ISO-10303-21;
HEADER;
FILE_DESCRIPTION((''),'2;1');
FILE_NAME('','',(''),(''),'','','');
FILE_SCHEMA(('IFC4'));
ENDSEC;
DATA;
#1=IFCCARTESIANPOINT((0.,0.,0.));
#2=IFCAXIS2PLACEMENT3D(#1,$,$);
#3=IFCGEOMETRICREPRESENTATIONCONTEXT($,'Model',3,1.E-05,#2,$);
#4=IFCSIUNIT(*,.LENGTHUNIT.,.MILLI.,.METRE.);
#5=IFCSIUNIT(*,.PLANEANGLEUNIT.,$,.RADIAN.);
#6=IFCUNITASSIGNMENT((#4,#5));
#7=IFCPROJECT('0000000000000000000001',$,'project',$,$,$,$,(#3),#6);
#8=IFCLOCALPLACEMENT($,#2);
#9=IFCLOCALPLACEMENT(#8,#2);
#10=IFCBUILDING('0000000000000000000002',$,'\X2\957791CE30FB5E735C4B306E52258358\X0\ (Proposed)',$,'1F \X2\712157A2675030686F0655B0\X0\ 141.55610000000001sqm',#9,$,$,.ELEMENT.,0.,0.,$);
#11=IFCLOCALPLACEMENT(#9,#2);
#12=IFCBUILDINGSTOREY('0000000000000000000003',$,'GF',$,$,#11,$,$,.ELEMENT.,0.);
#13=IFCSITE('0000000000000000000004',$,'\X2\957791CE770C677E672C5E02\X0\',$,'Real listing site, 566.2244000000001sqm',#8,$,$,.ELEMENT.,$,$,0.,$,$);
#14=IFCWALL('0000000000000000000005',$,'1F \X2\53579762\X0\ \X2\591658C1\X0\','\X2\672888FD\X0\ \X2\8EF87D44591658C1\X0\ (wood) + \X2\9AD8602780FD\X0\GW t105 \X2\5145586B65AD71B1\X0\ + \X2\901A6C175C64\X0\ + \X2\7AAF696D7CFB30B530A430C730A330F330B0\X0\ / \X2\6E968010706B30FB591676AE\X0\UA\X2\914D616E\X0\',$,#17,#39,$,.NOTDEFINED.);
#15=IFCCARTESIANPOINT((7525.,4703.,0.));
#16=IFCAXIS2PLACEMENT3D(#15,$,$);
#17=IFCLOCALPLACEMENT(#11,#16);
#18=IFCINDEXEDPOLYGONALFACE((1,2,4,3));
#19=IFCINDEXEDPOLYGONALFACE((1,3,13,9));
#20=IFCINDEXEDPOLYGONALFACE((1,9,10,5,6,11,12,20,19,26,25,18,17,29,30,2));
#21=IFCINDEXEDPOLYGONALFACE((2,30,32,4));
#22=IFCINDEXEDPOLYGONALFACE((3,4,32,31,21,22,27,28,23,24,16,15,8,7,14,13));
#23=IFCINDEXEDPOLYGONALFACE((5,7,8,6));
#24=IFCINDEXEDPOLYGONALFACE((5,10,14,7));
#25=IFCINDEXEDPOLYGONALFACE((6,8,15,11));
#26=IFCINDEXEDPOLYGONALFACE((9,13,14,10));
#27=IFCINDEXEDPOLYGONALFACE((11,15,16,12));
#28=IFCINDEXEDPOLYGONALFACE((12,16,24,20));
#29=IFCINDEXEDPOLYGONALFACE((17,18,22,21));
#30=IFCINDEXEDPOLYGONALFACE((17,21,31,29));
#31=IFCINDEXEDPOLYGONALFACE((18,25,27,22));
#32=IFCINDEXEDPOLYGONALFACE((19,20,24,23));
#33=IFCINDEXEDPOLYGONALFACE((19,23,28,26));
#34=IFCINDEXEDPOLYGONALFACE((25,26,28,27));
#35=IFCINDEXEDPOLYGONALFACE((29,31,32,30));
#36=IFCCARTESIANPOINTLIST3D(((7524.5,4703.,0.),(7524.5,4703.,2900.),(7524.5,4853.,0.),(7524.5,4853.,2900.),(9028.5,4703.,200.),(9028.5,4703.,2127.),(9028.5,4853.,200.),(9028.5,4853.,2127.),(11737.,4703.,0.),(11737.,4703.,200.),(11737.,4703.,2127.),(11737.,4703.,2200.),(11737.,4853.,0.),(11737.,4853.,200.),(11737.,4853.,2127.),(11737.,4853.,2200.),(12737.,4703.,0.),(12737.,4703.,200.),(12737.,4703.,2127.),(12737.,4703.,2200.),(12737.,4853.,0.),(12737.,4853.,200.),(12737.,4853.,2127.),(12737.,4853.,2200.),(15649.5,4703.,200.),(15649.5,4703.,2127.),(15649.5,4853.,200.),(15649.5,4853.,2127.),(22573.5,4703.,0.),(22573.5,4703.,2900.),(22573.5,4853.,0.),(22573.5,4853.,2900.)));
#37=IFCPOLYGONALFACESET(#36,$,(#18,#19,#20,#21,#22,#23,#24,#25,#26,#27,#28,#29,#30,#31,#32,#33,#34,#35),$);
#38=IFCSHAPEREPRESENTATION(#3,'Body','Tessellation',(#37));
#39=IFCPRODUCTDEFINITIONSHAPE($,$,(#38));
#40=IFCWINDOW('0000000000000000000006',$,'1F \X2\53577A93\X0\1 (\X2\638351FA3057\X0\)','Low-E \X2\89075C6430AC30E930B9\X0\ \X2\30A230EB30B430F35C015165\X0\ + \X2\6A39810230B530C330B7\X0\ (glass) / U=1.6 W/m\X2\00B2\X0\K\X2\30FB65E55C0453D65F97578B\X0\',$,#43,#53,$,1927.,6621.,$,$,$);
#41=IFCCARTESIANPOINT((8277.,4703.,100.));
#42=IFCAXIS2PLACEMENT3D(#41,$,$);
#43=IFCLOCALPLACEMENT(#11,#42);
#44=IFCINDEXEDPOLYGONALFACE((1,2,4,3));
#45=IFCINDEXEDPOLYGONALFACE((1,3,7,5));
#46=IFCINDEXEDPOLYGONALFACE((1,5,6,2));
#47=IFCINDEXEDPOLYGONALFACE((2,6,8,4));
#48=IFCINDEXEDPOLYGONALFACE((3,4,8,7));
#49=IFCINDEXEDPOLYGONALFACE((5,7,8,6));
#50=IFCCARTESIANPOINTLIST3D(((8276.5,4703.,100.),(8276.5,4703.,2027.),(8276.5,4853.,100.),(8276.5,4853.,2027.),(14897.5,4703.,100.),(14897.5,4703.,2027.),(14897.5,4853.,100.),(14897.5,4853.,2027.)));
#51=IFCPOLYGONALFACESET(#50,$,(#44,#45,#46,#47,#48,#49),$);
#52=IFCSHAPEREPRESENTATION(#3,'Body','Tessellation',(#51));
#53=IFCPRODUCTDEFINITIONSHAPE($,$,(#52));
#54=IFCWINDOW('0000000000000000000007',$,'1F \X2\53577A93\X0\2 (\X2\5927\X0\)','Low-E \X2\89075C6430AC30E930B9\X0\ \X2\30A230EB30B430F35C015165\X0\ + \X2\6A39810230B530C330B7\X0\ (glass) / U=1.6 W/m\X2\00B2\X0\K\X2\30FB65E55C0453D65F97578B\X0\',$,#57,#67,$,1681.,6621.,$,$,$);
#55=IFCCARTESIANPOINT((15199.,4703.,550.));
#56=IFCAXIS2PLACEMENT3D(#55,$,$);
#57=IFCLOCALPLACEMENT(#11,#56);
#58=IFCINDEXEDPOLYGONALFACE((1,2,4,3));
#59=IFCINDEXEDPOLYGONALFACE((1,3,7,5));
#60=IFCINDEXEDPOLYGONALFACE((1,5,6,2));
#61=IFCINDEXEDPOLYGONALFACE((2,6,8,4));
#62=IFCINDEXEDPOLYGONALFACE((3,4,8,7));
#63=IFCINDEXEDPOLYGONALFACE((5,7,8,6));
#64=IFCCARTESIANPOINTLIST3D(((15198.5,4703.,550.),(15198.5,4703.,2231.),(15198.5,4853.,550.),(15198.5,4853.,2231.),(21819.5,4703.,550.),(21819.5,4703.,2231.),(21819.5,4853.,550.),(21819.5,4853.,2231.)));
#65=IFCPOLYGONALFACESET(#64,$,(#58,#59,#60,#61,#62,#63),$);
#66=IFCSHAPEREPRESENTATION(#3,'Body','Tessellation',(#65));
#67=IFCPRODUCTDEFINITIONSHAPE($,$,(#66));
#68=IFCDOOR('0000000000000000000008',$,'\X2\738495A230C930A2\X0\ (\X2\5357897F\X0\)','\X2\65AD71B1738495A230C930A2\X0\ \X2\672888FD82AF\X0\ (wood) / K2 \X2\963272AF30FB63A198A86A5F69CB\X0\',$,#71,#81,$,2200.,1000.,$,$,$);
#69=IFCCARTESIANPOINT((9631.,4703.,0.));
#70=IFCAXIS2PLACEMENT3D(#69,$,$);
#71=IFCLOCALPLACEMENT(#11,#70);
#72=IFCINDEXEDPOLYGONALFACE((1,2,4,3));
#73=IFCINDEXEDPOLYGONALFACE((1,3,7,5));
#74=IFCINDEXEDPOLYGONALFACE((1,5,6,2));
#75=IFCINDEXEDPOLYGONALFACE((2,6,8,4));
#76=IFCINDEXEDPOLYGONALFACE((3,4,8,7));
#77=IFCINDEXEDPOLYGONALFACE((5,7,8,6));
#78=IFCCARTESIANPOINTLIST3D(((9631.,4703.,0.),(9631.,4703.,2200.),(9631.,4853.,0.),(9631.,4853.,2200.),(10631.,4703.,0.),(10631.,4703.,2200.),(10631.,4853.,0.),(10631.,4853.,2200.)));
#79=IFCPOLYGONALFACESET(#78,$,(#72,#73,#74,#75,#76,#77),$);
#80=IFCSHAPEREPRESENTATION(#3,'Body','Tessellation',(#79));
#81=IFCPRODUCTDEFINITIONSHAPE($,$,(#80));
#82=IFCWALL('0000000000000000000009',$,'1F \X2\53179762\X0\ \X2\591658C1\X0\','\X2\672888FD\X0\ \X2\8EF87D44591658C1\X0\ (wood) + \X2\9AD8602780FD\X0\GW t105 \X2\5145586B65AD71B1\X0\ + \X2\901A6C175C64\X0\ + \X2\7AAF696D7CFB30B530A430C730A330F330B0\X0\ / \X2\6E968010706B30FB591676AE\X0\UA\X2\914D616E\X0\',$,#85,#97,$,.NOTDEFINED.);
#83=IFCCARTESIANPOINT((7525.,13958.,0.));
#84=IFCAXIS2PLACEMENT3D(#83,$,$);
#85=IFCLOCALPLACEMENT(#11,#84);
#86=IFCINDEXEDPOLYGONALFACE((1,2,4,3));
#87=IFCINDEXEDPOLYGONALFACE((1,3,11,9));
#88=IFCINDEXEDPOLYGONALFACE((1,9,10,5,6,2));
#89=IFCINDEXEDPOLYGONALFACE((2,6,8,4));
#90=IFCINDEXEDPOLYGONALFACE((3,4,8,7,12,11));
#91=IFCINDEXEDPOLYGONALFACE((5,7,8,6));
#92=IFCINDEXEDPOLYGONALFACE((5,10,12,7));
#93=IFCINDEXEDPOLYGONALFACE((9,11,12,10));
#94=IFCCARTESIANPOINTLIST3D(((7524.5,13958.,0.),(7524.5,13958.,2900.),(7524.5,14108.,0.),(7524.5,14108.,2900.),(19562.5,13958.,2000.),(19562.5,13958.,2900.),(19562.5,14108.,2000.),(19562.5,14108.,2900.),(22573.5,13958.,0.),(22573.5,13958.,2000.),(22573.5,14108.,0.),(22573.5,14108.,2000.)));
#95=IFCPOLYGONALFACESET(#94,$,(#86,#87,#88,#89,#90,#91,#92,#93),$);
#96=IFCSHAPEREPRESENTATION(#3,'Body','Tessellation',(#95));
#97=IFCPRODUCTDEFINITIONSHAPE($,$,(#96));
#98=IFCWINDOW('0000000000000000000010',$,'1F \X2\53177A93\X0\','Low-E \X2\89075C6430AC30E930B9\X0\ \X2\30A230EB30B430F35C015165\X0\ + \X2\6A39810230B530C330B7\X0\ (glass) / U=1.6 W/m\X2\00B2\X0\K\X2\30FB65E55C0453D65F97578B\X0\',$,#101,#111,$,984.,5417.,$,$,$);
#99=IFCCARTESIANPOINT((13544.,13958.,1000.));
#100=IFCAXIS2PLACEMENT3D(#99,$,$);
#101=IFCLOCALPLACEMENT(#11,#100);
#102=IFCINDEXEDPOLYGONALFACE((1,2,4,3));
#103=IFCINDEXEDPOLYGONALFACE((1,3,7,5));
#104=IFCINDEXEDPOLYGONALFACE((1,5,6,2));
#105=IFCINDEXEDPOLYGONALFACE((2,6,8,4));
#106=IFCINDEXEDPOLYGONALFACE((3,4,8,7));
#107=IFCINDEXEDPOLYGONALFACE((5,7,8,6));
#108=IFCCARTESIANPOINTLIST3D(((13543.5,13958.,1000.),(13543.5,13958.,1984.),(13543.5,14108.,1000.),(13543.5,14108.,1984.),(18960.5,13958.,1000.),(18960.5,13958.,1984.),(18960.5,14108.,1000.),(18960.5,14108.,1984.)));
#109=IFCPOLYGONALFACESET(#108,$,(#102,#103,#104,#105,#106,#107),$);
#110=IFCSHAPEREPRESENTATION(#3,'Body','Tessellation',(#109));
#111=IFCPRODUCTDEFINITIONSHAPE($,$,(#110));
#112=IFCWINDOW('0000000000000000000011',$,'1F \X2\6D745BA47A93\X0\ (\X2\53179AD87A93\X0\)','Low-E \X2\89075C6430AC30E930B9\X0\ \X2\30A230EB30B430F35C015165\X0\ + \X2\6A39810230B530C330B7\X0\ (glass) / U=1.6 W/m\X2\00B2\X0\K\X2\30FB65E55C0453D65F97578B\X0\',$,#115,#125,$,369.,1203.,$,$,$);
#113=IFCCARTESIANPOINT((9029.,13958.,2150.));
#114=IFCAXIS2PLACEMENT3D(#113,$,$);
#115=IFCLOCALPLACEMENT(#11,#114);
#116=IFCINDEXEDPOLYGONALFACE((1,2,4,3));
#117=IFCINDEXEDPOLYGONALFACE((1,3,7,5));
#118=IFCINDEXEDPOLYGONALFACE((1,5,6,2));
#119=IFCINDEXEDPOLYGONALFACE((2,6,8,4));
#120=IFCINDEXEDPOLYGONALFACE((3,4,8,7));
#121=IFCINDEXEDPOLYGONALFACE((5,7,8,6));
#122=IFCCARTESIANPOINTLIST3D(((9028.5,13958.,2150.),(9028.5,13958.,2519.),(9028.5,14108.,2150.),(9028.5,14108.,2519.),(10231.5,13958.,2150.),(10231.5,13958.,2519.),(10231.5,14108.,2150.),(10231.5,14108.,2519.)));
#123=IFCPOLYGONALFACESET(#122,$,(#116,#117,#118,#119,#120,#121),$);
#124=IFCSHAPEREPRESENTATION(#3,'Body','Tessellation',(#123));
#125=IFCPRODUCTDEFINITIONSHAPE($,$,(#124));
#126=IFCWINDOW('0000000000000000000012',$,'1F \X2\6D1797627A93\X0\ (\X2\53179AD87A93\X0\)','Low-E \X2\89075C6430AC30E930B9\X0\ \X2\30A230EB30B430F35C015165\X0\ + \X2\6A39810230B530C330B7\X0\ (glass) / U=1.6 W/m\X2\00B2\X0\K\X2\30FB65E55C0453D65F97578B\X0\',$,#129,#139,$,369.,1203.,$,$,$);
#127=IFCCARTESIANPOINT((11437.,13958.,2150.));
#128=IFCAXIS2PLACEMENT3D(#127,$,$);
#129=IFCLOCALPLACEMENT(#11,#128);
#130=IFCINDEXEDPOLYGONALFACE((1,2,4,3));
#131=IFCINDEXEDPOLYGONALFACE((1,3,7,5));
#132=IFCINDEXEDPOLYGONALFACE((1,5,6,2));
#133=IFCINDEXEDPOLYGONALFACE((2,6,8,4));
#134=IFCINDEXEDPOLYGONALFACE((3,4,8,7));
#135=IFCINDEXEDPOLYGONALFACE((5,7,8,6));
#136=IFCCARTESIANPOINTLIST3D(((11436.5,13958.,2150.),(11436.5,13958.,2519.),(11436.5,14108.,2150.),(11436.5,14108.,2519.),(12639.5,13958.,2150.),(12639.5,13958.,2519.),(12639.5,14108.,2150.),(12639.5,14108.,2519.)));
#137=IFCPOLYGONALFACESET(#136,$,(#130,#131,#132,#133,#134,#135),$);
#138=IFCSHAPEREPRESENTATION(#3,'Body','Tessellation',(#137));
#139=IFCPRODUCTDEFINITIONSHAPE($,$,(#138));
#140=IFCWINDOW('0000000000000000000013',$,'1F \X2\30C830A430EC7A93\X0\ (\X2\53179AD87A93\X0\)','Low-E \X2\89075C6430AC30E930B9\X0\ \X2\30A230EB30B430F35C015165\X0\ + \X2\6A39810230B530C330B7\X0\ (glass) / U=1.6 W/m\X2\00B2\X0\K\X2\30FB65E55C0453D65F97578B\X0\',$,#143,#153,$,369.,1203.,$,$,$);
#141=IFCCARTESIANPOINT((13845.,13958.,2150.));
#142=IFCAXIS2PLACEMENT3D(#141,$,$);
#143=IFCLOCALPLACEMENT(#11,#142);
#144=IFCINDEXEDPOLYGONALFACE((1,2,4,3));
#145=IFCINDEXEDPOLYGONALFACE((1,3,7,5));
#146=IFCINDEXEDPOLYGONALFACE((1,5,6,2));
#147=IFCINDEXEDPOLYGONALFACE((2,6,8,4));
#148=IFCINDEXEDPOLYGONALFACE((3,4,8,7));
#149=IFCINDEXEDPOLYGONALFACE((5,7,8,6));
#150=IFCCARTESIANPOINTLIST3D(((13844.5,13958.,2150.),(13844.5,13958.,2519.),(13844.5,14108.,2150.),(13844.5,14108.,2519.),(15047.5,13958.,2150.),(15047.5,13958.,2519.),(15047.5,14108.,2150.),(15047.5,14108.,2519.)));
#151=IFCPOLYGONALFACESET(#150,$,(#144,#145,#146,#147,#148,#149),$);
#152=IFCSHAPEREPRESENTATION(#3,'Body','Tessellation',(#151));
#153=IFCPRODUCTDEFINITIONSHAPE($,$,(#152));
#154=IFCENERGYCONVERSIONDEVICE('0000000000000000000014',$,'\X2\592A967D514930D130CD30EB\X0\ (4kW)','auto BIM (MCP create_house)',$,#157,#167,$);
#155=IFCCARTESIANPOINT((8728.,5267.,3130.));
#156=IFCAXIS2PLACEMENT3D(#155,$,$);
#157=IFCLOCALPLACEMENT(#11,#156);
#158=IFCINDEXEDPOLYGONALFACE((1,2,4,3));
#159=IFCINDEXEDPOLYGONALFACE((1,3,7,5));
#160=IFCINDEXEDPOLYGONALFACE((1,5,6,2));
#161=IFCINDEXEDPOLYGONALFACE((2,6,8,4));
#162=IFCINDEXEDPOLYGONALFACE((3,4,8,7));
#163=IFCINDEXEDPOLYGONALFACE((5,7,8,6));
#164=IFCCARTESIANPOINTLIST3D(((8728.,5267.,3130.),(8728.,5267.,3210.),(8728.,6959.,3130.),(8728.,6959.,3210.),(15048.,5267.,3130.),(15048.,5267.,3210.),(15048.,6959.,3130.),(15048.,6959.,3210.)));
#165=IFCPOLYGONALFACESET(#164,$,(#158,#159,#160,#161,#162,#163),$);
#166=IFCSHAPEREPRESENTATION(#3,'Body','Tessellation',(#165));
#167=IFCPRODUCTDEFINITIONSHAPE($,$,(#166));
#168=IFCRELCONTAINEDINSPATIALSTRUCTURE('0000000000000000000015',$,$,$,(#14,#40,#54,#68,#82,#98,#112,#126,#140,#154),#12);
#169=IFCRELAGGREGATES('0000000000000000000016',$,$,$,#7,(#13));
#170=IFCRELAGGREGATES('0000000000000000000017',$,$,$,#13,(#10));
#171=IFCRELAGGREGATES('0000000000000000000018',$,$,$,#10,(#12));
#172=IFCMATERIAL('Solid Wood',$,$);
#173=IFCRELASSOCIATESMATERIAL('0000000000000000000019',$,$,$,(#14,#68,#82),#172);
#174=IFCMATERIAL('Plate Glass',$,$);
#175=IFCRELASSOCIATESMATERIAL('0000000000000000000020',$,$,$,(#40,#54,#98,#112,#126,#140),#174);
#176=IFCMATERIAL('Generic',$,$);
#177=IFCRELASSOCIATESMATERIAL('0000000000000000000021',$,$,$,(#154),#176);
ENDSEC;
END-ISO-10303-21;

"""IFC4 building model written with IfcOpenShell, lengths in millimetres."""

from ifc_helpers import new_model, si_unit, frame, frame_2d, origin, place, context, project, spatial, rectangle, extrude, material, element, fill, save


model = new_model("IFC4")

# Units and contexts
model_context = context("Model", 3, precision=1e-05, world=origin())
ifc_project = project(units=[si_unit("LENGTHUNIT", "METRE", prefix="MILLI"), si_unit("PLANEANGLEUNIT", "RADIAN")], contexts=[model_context])

# Site, building, storey
site_placement = place(None, origin())
site = spatial("IfcSite", under=ifc_project, at=site_placement, Name="長野県松本市", ObjectType="Real listing site, 566.2244000000001sqm", CompositionType="ELEMENT", RefElevation=0.0)
building_placement = place(site_placement, origin())
building = spatial("IfcBuilding", under=site, at=building_placement, Name="長野・平屋の別荘 (Proposed)", ObjectType="1F 無垢材と漆喰 141.55610000000001sqm", CompositionType="ELEMENT", ElevationOfRefHeight=0.0, ElevationOfTerrain=0.0)
storey_placement = place(building_placement, origin())
storey = spatial("IfcBuildingStorey", under=building, at=storey_placement, Name="GF", CompositionType="ELEMENT", Elevation=0.0)

# Shared definitions
ifc_material_1 = material(Name="Solid Wood")

# Wall, openings, windows, door
wall_1_placement = place(storey_placement, frame((7525.0, 4703.0, 0.0)))
wall_1 = element("IfcWall", 1, at=wall_1_placement, inside=storey, material=ifc_material_1, Name="1F 南面 外壁", Description="木製 軸組外壁 (wood) + 高性能GW t105 充填断熱 + 通気層 + 窯業系サイディング / 準耐火・外皮UA配慮", PredefinedType="NOTDEFINED", context=model_context, shape_type="SweptSolid", body=[
    extrude(rectangle(XDim=15049.0, YDim=150.0, at=frame_2d((7524.0, 75.0))), frame((7525.0, 4703.0, 0.0)), (0.0, 0.0, 1.0), 2900.0),
])
opening_1_placement = place(storey_placement, frame((8277.0, 4703.0, 100.0)))
opening_1 = element("IfcOpeningElement", 2, at=opening_1_placement, cuts=wall_1, PredefinedType="NOTDEFINED", context=model_context, shape_type="SweptSolid", body=[
    extrude(rectangle(XDim=6621.0, YDim=150.0, at=frame_2d((3310.0, 75.0))), frame((8277.0, 4703.0, 100.0)), (0.0, 0.0, 1.0), 1927.0),
])
opening_2_placement = place(storey_placement, frame((15199.0, 4703.0, 550.0)))
opening_2 = element("IfcOpeningElement", 3, at=opening_2_placement, cuts=wall_1, PredefinedType="NOTDEFINED", context=model_context, shape_type="SweptSolid", body=[
    extrude(rectangle(XDim=6621.0, YDim=150.0, at=frame_2d((3310.0, 75.0))), frame((15199.0, 4703.0, 550.0)), (0.0, 0.0, 1.0), 1681.0),
])
opening_3_placement = place(storey_placement, frame((9631.0, 4703.0, 0.0)))
opening_3 = element("IfcOpeningElement", 4, at=opening_3_placement, cuts=wall_1, PredefinedType="NOTDEFINED", context=model_context, shape_type="SweptSolid", body=[
    extrude(rectangle(XDim=1000.0, YDim=150.0, at=frame_2d((500.0, 75.0))), frame((9631.0, 4703.0, 0.0)), (0.0, 0.0, 1.0), 2200.0),
])
ifc_material_2 = material(Name="Plate Glass")
window_1_placement = place(storey_placement, frame((8277.0, 4703.0, 100.0)))
window_1 = element("IfcWindow", 5, at=window_1_placement, inside=storey, material=ifc_material_2, Name="1F 南窓1 (掃出し)", Description="Low-E 複層ガラス アルゴン封入 + 樹脂サッシ (glass) / U=1.6 W/m²K・日射取得型", OverallHeight=1927.0, OverallWidth=6621.0, context=model_context, shape_type="SweptSolid", body=[
    extrude(rectangle(XDim=6621.0, YDim=150.0, at=frame_2d((3310.0, 75.0))), frame((8277.0, 4703.0, 100.0)), (0.0, 0.0, 1.0), 1927.0),
])
fill(opening_1, window_1)
window_2_placement = place(storey_placement, frame((15199.0, 4703.0, 550.0)))
window_2 = element("IfcWindow", 6, at=window_2_placement, inside=storey, material=ifc_material_2, Name="1F 南窓2 (大)", Description="Low-E 複層ガラス アルゴン封入 + 樹脂サッシ (glass) / U=1.6 W/m²K・日射取得型", OverallHeight=1681.0, OverallWidth=6621.0, context=model_context, shape_type="SweptSolid", body=[
    extrude(rectangle(XDim=6621.0, YDim=150.0, at=frame_2d((3310.0, 75.0))), frame((15199.0, 4703.0, 550.0)), (0.0, 0.0, 1.0), 1681.0),
])
fill(opening_2, window_2)
door_1_placement = place(storey_placement, frame((9631.0, 4703.0, 0.0)))
door_1 = element("IfcDoor", 7, at=door_1_placement, inside=storey, material=ifc_material_1, Name="玄関ドア (南西)", Description="断熱玄関ドア 木製芯 (wood) / K2 防犯・採風機構", OverallHeight=2200.0, OverallWidth=1000.0, context=model_context, shape_type="SweptSolid", body=[
    extrude(rectangle(XDim=1000.0, YDim=150.0, at=frame_2d((500.0, 75.0))), frame((9631.0, 4703.0, 0.0)), (0.0, 0.0, 1.0), 2200.0),
])
fill(opening_3, door_1)

# Wall, openings, windows
wall_2_placement = place(storey_placement, frame((7525.0, 13958.0, 0.0)))
wall_2 = element("IfcWall", 8, at=wall_2_placement, inside=storey, material=ifc_material_1, Name="1F 北面 外壁", Description="木製 軸組外壁 (wood) + 高性能GW t105 充填断熱 + 通気層 + 窯業系サイディング / 準耐火・外皮UA配慮", PredefinedType="NOTDEFINED", context=model_context, shape_type="SweptSolid", body=[
    extrude(rectangle(XDim=15049.0, YDim=150.0, at=frame_2d((7524.0, 75.0))), frame((7525.0, 13958.0, 0.0)), (0.0, 0.0, 1.0), 2900.0),
])
opening_4_placement = place(storey_placement, frame((13544.0, 13958.0, 1000.0)))
opening_4 = element("IfcOpeningElement", 9, at=opening_4_placement, cuts=wall_2, PredefinedType="NOTDEFINED", context=model_context, shape_type="SweptSolid", body=[
    extrude(rectangle(XDim=5417.0, YDim=150.0, at=frame_2d((2708.0, 75.0))), frame((13544.0, 13958.0, 1000.0)), (0.0, 0.0, 1.0), 984.0),
])
opening_5_placement = place(storey_placement, frame((9029.0, 13958.0, 2150.0)))
opening_5 = element("IfcOpeningElement", 10, at=opening_5_placement, cuts=wall_2, PredefinedType="NOTDEFINED", context=model_context, shape_type="SweptSolid", body=[
    extrude(rectangle(XDim=1203.0, YDim=150.0, at=frame_2d((601.0, 75.0))), frame((9029.0, 13958.0, 2150.0)), (0.0, 0.0, 1.0), 369.0),
])
opening_6_placement = place(storey_placement, frame((11437.0, 13958.0, 2150.0)))
opening_6 = element("IfcOpeningElement", 11, at=opening_6_placement, cuts=wall_2, PredefinedType="NOTDEFINED", context=model_context, shape_type="SweptSolid", body=[
    extrude(rectangle(XDim=1203.0, YDim=150.0, at=frame_2d((601.0, 75.0))), frame((11437.0, 13958.0, 2150.0)), (0.0, 0.0, 1.0), 369.0),
])
opening_7_placement = place(storey_placement, frame((13845.0, 13958.0, 2150.0)))
opening_7 = element("IfcOpeningElement", 12, at=opening_7_placement, cuts=wall_2, PredefinedType="NOTDEFINED", context=model_context, shape_type="SweptSolid", body=[
    extrude(rectangle(XDim=1203.0, YDim=150.0, at=frame_2d((601.0, 75.0))), frame((13845.0, 13958.0, 2150.0)), (0.0, 0.0, 1.0), 369.0),
])
window_3_placement = place(storey_placement, frame((13544.0, 13958.0, 1000.0)))
window_3 = element("IfcWindow", 13, at=window_3_placement, inside=storey, material=ifc_material_2, Name="1F 北窓", Description="Low-E 複層ガラス アルゴン封入 + 樹脂サッシ (glass) / U=1.6 W/m²K・日射取得型", OverallHeight=984.0, OverallWidth=5417.0, context=model_context, shape_type="SweptSolid", body=[
    extrude(rectangle(XDim=5417.0, YDim=150.0, at=frame_2d((2708.0, 75.0))), frame((13544.0, 13958.0, 1000.0)), (0.0, 0.0, 1.0), 984.0),
])
fill(opening_4, window_3)
window_4_placement = place(storey_placement, frame((9029.0, 13958.0, 2150.0)))
window_4 = element("IfcWindow", 14, at=window_4_placement, inside=storey, material=ifc_material_2, Name="1F 浴室窓 (北高窓)", Description="Low-E 複層ガラス アルゴン封入 + 樹脂サッシ (glass) / U=1.6 W/m²K・日射取得型", OverallHeight=369.0, OverallWidth=1203.0, context=model_context, shape_type="SweptSolid", body=[
    extrude(rectangle(XDim=1203.0, YDim=150.0, at=frame_2d((601.0, 75.0))), frame((9029.0, 13958.0, 2150.0)), (0.0, 0.0, 1.0), 369.0),
])
fill(opening_5, window_4)
window_5_placement = place(storey_placement, frame((11437.0, 13958.0, 2150.0)))
window_5 = element("IfcWindow", 15, at=window_5_placement, inside=storey, material=ifc_material_2, Name="1F 洗面窓 (北高窓)", Description="Low-E 複層ガラス アルゴン封入 + 樹脂サッシ (glass) / U=1.6 W/m²K・日射取得型", OverallHeight=369.0, OverallWidth=1203.0, context=model_context, shape_type="SweptSolid", body=[
    extrude(rectangle(XDim=1203.0, YDim=150.0, at=frame_2d((601.0, 75.0))), frame((11437.0, 13958.0, 2150.0)), (0.0, 0.0, 1.0), 369.0),
])
fill(opening_6, window_5)
window_6_placement = place(storey_placement, frame((13845.0, 13958.0, 2150.0)))
window_6 = element("IfcWindow", 16, at=window_6_placement, inside=storey, material=ifc_material_2, Name="1F トイレ窓 (北高窓)", Description="Low-E 複層ガラス アルゴン封入 + 樹脂サッシ (glass) / U=1.6 W/m²K・日射取得型", OverallHeight=369.0, OverallWidth=1203.0, context=model_context, shape_type="SweptSolid", body=[
    extrude(rectangle(XDim=1203.0, YDim=150.0, at=frame_2d((601.0, 75.0))), frame((13845.0, 13958.0, 2150.0)), (0.0, 0.0, 1.0), 369.0),
])
fill(opening_7, window_6)

# Shared definitions
ifc_material_3 = material(Name="Generic")

# Energy conversion device
energy_conversion_device_placement = place(storey_placement, frame((8728.0, 5267.0, 3130.0)))
element("IfcEnergyConversionDevice", 17, at=energy_conversion_device_placement, inside=storey, material=ifc_material_3, Name="太陽光パネル (4kW)", Description="auto BIM (MCP create_house)", context=model_context, shape_type="SweptSolid", body=[
    extrude(rectangle(XDim=6320.0, YDim=1692.0, at=frame_2d((3160.0, 846.0))), frame((8728.0, 5267.0, 3130.0)), (0.0, 0.0, 1.0), 80.0),
])

save(model, "model.ifc")
